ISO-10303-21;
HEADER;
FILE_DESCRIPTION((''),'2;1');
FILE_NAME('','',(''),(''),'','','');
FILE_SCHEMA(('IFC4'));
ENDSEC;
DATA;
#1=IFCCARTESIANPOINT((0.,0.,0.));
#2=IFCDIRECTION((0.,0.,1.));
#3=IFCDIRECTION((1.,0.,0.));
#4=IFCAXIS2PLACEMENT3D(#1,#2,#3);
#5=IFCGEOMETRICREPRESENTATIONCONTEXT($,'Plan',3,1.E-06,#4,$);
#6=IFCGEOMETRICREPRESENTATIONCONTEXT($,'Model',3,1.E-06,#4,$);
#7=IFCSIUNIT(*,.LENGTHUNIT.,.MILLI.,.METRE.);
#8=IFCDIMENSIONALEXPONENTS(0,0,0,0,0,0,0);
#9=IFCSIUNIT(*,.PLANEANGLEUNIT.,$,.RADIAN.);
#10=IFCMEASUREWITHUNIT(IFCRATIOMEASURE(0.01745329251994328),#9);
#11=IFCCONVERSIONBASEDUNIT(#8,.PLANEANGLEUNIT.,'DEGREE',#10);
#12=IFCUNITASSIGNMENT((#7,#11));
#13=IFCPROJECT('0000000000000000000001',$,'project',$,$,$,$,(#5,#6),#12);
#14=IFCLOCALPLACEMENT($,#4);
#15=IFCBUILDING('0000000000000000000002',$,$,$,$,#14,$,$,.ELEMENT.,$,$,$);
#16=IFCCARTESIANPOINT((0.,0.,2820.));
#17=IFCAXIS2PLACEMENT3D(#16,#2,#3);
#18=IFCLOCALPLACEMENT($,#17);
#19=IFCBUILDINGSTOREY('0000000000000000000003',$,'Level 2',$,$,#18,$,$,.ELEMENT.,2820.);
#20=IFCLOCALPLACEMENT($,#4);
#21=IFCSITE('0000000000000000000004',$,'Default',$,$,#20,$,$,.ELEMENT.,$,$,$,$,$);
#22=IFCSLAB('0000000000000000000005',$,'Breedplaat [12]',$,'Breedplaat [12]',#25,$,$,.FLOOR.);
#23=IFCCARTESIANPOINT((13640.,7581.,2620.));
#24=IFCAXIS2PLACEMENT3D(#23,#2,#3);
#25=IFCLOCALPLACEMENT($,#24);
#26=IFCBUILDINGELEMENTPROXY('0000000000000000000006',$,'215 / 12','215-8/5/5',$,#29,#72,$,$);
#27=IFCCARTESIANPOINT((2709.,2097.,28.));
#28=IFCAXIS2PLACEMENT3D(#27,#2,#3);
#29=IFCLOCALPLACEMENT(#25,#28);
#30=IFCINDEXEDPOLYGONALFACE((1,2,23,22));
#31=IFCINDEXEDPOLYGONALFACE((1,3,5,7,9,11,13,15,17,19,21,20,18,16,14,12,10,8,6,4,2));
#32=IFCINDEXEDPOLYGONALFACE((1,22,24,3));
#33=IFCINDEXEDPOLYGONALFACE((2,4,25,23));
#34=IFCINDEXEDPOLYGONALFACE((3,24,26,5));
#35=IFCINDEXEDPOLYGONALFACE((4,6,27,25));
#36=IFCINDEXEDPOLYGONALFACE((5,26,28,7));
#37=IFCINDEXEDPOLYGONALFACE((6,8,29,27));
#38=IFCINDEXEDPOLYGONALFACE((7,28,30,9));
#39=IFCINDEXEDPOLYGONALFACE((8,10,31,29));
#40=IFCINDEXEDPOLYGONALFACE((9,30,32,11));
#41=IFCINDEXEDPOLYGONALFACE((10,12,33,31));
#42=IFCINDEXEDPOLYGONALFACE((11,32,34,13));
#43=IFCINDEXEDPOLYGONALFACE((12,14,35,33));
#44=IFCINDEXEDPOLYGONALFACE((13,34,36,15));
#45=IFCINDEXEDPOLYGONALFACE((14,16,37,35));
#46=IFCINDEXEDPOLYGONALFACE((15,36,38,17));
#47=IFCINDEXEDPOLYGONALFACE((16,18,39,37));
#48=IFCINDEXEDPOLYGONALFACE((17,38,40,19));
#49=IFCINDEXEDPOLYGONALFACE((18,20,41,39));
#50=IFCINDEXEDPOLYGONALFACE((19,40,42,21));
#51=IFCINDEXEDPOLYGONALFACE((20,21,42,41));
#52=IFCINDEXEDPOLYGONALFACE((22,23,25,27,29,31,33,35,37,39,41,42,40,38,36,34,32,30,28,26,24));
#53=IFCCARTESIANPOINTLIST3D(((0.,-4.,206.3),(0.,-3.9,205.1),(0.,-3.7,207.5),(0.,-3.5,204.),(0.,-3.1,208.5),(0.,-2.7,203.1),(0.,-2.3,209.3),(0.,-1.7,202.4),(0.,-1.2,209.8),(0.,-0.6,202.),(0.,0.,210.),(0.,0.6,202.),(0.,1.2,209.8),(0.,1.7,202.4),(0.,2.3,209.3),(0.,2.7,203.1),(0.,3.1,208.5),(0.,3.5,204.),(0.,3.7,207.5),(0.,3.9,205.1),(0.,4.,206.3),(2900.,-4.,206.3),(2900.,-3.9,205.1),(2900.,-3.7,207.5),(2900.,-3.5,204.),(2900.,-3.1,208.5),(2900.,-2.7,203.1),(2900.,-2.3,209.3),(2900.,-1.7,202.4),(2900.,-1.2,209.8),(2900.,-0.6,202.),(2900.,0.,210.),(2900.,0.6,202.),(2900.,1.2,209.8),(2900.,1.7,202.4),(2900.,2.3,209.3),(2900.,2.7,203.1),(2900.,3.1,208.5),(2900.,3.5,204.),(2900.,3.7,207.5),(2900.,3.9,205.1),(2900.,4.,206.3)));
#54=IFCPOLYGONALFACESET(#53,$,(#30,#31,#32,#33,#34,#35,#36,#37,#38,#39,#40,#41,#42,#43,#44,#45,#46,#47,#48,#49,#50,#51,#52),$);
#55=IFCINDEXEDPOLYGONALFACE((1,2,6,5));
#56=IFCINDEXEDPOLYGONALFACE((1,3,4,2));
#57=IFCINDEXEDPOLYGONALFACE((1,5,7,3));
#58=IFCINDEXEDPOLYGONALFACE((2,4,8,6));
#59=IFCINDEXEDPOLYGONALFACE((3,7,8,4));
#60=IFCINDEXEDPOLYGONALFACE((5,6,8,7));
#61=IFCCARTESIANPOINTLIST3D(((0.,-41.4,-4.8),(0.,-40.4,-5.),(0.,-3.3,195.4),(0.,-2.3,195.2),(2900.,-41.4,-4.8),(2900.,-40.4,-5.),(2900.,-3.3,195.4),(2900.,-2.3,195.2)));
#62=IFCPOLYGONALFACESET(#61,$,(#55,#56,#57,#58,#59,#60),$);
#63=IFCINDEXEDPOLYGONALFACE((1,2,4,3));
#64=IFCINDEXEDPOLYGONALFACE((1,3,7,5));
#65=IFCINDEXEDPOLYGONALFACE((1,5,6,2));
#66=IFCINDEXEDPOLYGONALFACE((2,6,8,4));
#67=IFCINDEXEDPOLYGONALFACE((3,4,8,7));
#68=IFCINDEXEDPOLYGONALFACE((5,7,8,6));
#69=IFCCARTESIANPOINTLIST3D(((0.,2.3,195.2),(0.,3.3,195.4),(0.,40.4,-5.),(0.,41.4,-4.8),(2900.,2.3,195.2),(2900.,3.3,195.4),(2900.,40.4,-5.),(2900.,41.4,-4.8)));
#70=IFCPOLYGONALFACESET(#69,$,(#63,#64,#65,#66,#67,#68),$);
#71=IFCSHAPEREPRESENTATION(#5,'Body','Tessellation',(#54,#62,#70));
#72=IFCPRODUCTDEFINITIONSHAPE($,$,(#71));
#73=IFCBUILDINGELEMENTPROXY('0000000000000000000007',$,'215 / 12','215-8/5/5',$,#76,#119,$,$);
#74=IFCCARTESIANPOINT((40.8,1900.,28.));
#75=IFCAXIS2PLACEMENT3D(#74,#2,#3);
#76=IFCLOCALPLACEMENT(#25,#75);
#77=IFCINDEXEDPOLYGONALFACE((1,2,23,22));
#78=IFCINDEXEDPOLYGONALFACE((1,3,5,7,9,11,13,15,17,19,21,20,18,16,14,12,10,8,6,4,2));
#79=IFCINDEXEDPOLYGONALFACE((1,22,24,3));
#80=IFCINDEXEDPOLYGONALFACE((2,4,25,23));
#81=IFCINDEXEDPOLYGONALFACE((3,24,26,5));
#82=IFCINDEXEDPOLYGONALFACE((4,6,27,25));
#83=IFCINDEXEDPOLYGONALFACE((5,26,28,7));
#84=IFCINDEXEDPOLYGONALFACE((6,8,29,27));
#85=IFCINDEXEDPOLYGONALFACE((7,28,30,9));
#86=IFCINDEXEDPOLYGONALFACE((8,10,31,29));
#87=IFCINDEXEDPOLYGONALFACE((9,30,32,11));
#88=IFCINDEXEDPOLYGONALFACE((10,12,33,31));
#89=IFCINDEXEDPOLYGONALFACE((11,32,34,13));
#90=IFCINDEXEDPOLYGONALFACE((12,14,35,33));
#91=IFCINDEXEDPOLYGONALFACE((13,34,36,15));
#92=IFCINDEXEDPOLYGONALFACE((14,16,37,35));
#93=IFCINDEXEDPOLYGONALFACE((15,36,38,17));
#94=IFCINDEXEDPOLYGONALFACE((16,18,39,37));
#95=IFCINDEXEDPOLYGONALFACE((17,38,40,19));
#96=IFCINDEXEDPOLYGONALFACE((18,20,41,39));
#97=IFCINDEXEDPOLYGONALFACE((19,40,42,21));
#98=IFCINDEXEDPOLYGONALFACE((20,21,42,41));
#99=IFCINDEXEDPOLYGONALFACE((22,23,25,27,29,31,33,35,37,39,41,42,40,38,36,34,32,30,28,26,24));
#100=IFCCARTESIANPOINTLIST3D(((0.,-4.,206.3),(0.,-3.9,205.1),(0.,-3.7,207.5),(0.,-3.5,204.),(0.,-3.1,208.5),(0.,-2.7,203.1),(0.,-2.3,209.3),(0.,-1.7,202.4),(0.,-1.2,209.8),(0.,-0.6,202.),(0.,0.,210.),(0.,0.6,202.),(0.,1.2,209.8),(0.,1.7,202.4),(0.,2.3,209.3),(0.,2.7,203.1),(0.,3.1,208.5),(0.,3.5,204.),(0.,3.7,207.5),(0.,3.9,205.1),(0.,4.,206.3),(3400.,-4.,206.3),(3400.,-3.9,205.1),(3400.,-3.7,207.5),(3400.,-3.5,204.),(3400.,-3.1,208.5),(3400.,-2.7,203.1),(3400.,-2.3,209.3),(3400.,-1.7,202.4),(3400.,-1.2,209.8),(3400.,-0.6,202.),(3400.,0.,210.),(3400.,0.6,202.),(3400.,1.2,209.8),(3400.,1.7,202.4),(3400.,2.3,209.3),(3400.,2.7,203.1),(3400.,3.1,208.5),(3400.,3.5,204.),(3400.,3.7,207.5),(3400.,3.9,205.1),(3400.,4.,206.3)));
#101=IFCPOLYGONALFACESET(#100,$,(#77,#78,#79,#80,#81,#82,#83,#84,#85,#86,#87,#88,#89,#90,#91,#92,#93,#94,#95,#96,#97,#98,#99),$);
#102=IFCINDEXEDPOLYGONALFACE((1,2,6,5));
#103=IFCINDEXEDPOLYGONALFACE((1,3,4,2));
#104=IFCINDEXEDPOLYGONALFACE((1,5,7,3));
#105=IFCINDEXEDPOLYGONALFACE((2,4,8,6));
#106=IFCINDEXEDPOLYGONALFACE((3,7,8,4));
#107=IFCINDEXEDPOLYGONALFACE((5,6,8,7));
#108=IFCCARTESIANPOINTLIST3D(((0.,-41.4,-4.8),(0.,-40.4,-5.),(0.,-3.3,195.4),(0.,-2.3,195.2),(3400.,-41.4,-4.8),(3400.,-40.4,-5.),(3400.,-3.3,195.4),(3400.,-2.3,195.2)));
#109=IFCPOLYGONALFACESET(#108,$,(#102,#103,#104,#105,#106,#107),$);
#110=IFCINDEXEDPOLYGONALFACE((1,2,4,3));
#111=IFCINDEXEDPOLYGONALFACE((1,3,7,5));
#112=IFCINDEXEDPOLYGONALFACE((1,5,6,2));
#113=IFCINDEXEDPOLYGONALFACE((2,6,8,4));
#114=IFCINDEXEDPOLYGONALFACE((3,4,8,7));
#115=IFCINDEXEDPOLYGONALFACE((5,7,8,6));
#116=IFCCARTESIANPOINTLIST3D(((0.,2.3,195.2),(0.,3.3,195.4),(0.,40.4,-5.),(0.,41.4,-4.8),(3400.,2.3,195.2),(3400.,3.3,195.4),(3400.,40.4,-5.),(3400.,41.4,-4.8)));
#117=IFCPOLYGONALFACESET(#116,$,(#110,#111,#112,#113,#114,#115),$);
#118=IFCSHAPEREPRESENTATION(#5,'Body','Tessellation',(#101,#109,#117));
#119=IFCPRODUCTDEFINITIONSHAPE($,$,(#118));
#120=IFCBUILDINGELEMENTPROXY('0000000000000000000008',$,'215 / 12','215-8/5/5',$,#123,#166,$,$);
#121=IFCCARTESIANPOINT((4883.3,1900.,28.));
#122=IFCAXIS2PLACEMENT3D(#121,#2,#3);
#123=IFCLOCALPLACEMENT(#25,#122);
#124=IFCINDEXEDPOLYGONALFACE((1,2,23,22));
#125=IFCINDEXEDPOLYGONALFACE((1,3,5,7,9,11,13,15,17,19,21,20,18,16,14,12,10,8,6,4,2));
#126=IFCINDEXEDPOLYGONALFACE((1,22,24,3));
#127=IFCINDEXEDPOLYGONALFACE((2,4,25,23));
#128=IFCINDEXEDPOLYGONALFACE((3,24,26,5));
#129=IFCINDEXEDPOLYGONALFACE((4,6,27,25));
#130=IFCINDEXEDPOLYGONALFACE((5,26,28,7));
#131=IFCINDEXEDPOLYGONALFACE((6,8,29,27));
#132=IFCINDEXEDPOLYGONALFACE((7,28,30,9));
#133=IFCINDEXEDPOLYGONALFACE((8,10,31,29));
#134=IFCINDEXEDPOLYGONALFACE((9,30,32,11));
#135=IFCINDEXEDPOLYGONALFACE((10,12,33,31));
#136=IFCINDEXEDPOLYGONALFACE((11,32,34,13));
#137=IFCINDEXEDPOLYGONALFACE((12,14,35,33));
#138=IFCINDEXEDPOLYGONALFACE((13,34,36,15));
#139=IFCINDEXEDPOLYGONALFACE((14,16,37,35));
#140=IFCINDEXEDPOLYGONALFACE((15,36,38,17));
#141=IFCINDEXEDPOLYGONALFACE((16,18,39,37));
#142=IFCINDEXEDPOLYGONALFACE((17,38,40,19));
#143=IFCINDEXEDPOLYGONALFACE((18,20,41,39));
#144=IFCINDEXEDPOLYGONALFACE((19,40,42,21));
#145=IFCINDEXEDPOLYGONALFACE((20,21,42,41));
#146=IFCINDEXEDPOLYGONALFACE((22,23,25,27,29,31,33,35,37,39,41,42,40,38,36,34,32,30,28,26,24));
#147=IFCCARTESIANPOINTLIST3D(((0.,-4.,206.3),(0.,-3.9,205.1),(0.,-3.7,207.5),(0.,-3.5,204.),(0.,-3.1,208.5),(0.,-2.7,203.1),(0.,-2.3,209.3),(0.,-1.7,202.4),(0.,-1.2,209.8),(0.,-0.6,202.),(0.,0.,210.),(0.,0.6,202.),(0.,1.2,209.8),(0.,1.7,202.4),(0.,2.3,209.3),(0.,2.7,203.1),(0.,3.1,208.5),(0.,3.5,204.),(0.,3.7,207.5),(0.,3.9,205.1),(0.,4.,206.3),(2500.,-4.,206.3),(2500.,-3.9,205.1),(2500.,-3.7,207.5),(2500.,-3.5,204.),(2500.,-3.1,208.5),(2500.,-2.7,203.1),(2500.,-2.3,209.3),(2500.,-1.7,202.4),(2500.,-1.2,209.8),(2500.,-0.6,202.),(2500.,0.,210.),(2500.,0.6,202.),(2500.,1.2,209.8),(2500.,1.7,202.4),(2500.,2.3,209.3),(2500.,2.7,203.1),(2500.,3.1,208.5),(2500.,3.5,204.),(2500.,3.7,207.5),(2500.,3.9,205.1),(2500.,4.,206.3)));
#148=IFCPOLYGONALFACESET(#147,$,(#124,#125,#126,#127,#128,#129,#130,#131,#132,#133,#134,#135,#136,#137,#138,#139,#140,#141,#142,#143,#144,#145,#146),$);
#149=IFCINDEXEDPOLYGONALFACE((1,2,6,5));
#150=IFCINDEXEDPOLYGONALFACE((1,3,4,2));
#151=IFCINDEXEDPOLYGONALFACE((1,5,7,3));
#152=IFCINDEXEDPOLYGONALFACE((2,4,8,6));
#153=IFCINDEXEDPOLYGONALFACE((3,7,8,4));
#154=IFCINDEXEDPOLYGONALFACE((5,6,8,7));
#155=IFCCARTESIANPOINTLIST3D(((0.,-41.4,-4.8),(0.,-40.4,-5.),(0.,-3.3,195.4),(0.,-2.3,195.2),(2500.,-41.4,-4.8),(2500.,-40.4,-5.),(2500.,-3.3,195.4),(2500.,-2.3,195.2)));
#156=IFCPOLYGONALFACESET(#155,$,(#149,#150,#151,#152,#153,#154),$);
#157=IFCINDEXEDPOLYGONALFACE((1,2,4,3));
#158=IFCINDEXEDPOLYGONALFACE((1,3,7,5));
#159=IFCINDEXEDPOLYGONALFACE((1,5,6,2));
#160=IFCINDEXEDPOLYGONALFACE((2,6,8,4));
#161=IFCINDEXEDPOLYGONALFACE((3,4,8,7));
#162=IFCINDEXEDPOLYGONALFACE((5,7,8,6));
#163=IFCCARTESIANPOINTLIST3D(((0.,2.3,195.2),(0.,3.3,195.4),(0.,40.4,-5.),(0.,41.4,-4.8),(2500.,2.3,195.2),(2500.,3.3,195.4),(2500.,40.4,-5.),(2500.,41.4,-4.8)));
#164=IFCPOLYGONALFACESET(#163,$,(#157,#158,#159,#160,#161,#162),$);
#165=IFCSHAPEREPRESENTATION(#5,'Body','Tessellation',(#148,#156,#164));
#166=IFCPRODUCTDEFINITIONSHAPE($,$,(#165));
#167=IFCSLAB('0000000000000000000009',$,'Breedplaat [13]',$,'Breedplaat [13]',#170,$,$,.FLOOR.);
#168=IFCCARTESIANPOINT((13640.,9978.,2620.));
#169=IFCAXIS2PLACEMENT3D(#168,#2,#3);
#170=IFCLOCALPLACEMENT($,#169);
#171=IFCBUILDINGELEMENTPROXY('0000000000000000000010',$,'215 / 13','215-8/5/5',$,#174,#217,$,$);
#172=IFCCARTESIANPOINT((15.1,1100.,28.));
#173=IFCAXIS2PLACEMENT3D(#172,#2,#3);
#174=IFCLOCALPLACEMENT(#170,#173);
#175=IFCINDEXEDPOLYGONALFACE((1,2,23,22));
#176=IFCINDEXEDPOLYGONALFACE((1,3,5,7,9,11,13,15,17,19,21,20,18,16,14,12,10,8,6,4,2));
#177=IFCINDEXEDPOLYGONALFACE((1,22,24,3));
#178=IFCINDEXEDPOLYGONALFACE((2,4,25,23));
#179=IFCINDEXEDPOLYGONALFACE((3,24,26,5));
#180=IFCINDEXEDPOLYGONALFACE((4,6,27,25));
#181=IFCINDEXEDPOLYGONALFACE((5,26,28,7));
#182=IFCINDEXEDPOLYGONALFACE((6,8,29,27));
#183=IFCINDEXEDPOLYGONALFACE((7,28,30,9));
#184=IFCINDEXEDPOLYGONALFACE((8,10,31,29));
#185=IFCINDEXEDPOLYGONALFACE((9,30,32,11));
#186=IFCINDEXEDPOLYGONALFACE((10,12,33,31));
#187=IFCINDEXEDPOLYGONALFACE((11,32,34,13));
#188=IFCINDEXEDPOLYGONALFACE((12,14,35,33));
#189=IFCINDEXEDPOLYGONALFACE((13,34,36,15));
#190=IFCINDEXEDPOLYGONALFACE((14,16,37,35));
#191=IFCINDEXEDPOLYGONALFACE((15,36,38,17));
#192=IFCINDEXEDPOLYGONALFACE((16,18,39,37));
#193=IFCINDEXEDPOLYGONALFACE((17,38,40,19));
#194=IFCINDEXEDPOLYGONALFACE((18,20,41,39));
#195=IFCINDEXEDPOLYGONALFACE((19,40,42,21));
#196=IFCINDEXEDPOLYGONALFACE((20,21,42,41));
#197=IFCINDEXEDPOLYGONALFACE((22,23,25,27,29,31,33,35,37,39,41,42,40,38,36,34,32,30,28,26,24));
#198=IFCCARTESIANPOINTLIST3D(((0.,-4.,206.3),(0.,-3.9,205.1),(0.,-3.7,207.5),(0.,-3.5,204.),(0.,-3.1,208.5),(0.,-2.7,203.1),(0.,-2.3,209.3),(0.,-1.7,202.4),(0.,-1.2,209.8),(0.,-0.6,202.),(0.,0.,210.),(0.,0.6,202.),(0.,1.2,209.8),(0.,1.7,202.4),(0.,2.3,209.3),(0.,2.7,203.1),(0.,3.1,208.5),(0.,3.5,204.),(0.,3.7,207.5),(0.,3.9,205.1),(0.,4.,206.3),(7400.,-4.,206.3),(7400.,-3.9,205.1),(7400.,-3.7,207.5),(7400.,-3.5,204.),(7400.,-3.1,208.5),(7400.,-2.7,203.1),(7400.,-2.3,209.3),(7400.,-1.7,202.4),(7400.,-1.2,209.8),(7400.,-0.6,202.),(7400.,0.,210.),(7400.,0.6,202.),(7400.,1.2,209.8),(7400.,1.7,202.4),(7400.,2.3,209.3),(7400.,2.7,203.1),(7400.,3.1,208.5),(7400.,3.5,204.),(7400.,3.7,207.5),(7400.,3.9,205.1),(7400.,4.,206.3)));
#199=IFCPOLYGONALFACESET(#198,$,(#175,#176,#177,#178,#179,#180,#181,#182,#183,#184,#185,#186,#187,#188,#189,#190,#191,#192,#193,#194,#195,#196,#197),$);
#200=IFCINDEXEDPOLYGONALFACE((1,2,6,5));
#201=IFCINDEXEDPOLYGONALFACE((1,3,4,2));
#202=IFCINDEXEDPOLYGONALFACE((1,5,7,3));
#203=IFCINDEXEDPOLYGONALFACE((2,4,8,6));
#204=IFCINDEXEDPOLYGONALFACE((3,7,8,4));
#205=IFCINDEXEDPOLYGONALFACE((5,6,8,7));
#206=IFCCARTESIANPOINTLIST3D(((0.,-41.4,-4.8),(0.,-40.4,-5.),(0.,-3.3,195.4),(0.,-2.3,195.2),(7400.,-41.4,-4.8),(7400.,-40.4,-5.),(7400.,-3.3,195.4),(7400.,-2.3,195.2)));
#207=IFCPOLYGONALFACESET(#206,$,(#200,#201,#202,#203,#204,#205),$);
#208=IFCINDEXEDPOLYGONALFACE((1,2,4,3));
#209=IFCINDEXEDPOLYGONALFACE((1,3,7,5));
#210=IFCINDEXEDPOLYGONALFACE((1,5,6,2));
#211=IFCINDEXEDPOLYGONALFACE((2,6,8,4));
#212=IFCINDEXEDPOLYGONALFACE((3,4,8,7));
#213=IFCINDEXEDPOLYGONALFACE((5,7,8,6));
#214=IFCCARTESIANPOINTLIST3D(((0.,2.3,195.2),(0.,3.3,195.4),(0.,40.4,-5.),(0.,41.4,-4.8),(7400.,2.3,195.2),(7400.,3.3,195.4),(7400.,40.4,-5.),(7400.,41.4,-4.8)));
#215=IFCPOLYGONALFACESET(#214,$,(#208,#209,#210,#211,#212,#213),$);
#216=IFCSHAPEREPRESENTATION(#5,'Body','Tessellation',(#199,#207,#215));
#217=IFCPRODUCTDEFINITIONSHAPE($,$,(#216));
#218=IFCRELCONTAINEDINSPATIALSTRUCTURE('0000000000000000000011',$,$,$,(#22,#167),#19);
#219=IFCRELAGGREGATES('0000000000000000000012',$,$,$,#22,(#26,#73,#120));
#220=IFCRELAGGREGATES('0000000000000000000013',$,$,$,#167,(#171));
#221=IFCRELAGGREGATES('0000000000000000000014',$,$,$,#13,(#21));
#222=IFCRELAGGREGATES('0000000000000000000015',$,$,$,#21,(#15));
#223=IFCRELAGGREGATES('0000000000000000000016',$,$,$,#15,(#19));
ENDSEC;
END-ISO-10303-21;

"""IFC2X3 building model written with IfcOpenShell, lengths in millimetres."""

from ifc_helpers import new_model, entity, si_unit, converted_unit, frame, origin_with_axes, origin_2d_with_axis, place, context, project, spatial, rectangle, circle, extrude, element, aggregate, save


model = new_model("IFC2X3")

# Units and contexts
plan_context = context("Plan", 3, precision=1e-06, world=origin_with_axes())
model_context = context("Model", 3, precision=1e-06, world=origin_with_axes())
ifc_project = project(units=[si_unit("LENGTHUNIT", "METRE", prefix="MILLI"), converted_unit("PLANEANGLEUNIT", "DEGREE", entity("IfcRatioMeasure", 0.01745329251994328), si_unit("PLANEANGLEUNIT", "RADIAN"), dimensions=[0, 0, 0, 0, 0, 0, 0])], contexts=[plan_context, model_context])

# Site, building, storey
site_placement = place(None, origin_with_axes())
site = spatial("IfcSite", under=ifc_project, at=site_placement, Name="Default", CompositionType="ELEMENT")
building_placement = place(None, origin_with_axes())
building = spatial("IfcBuilding", under=site, at=building_placement, CompositionType="ELEMENT")
storey_placement = place(None, frame((0.0, 0.0, 2820.0), z_axis=(0.0, 0.0, 1.0), x_axis=(1.0, 0.0, 0.0)))
storey = spatial("IfcBuildingStorey", under=building, at=storey_placement, Name="Level 2", CompositionType="ELEMENT", Elevation=2820.0)

# Slab, building element proxies
slab_1_placement = place(None, frame((13640.0, 7581.0, 2620.0), z_axis=(0.0, 0.0, 1.0), x_axis=(1.0, 0.0, 0.0)))
slab_1 = element("IfcSlab", 1, at=slab_1_placement, inside=storey, Name="Breedplaat [12]", ObjectType="Breedplaat [12]", PredefinedType="FLOOR")
proxy_1_placement = place(slab_1_placement, frame((2709.0, 2097.0, 28.0), z_axis=(0.0, 0.0, 1.0), x_axis=(1.0, 0.0, 0.0)))
proxy_1 = element("IfcBuildingElementProxy", 2, at=proxy_1_placement, Name="215 / 12", Description="215-8/5/5", context=plan_context, shape_type="SweptSolid", body=[
    extrude(circle(Radius=4.0, at=origin_2d_with_axis()), frame((0.0, 0.0, 206.0), z_axis=(1.0, 0.0, 0.0), x_axis=(0.0, 0.0, 1.0)), (0.0, 0.0, 1.0), 2900.0),
    extrude(rectangle(XDim=203.8, YDim=1.0, at=origin_2d_with_axis()), frame((0.0, -21.9, 95.2), z_axis=(1.0, 0.0, 0.0), x_axis=(0.0, 0.187112, 0.982339)), (0.0, 0.0, 1.0), 2900.0),
    extrude(rectangle(XDim=203.8, YDim=1.0, at=origin_2d_with_axis()), frame((0.0, 21.9, 95.2), z_axis=(1.0, 0.0, 0.0), x_axis=(0.0, -0.187112, 0.982339)), (0.0, 0.0, 1.0), 2900.0),
])
proxy_2_placement = place(slab_1_placement, frame((40.8, 1900.0, 28.0), z_axis=(0.0, 0.0, 1.0), x_axis=(1.0, 0.0, 0.0)))
proxy_2 = element("IfcBuildingElementProxy", 3, at=proxy_2_placement, Name="215 / 12", Description="215-8/5/5", context=plan_context, shape_type="SweptSolid", body=[
    extrude(circle(Radius=4.0, at=origin_2d_with_axis()), frame((0.0, 0.0, 206.0), z_axis=(1.0, 0.0, 0.0), x_axis=(0.0, 0.0, 1.0)), (0.0, 0.0, 1.0), 3400.0),
    extrude(rectangle(XDim=203.8, YDim=1.0, at=origin_2d_with_axis()), frame((0.0, -21.9, 95.2), z_axis=(1.0, 0.0, 0.0), x_axis=(0.0, 0.187112, 0.982339)), (0.0, 0.0, 1.0), 3400.0),
    extrude(rectangle(XDim=203.8, YDim=1.0, at=origin_2d_with_axis()), frame((0.0, 21.9, 95.2), z_axis=(1.0, 0.0, 0.0), x_axis=(0.0, -0.187112, 0.982339)), (0.0, 0.0, 1.0), 3400.0),
])
proxy_3_placement = place(slab_1_placement, frame((4883.3, 1900.0, 28.0), z_axis=(0.0, 0.0, 1.0), x_axis=(1.0, 0.0, 0.0)))
proxy_3 = element("IfcBuildingElementProxy", 4, at=proxy_3_placement, Name="215 / 12", Description="215-8/5/5", context=plan_context, shape_type="SweptSolid", body=[
    extrude(circle(Radius=4.0, at=origin_2d_with_axis()), frame((0.0, 0.0, 206.0), z_axis=(1.0, 0.0, 0.0), x_axis=(0.0, 0.0, 1.0)), (0.0, 0.0, 1.0), 2500.0),
    extrude(rectangle(XDim=203.8, YDim=1.0, at=origin_2d_with_axis()), frame((0.0, -21.9, 95.2), z_axis=(1.0, 0.0, 0.0), x_axis=(0.0, 0.187112, 0.982339)), (0.0, 0.0, 1.0), 2500.0),
    extrude(rectangle(XDim=203.8, YDim=1.0, at=origin_2d_with_axis()), frame((0.0, 21.9, 95.2), z_axis=(1.0, 0.0, 0.0), x_axis=(0.0, -0.187112, 0.982339)), (0.0, 0.0, 1.0), 2500.0),
])
aggregate(slab_1, [proxy_1, proxy_2, proxy_3])

# Slab, building element proxy
slab_2_placement = place(None, frame((13640.0, 9978.0, 2620.0), z_axis=(0.0, 0.0, 1.0), x_axis=(1.0, 0.0, 0.0)))
slab_2 = element("IfcSlab", 5, at=slab_2_placement, inside=storey, Name="Breedplaat [13]", ObjectType="Breedplaat [13]", PredefinedType="FLOOR")
proxy_4_placement = place(slab_2_placement, frame((15.1, 1100.0, 28.0), z_axis=(0.0, 0.0, 1.0), x_axis=(1.0, 0.0, 0.0)))
proxy_4 = element("IfcBuildingElementProxy", 6, at=proxy_4_placement, Name="215 / 13", Description="215-8/5/5", context=plan_context, shape_type="SweptSolid", body=[
    extrude(circle(Radius=4.0, at=origin_2d_with_axis()), frame((0.0, 0.0, 206.0), z_axis=(1.0, 0.0, 0.0), x_axis=(0.0, 0.0, 1.0)), (0.0, 0.0, 1.0), 7400.0),
    extrude(rectangle(XDim=203.8, YDim=1.0, at=origin_2d_with_axis()), frame((0.0, -21.9, 95.2), z_axis=(1.0, 0.0, 0.0), x_axis=(0.0, 0.187112, 0.982339)), (0.0, 0.0, 1.0), 7400.0),
    extrude(rectangle(XDim=203.8, YDim=1.0, at=origin_2d_with_axis()), frame((0.0, 21.9, 95.2), z_axis=(1.0, 0.0, 0.0), x_axis=(0.0, -0.187112, 0.982339)), (0.0, 0.0, 1.0), 7400.0),
])
aggregate(slab_2, [proxy_4])

save(model, "model.ifc")
